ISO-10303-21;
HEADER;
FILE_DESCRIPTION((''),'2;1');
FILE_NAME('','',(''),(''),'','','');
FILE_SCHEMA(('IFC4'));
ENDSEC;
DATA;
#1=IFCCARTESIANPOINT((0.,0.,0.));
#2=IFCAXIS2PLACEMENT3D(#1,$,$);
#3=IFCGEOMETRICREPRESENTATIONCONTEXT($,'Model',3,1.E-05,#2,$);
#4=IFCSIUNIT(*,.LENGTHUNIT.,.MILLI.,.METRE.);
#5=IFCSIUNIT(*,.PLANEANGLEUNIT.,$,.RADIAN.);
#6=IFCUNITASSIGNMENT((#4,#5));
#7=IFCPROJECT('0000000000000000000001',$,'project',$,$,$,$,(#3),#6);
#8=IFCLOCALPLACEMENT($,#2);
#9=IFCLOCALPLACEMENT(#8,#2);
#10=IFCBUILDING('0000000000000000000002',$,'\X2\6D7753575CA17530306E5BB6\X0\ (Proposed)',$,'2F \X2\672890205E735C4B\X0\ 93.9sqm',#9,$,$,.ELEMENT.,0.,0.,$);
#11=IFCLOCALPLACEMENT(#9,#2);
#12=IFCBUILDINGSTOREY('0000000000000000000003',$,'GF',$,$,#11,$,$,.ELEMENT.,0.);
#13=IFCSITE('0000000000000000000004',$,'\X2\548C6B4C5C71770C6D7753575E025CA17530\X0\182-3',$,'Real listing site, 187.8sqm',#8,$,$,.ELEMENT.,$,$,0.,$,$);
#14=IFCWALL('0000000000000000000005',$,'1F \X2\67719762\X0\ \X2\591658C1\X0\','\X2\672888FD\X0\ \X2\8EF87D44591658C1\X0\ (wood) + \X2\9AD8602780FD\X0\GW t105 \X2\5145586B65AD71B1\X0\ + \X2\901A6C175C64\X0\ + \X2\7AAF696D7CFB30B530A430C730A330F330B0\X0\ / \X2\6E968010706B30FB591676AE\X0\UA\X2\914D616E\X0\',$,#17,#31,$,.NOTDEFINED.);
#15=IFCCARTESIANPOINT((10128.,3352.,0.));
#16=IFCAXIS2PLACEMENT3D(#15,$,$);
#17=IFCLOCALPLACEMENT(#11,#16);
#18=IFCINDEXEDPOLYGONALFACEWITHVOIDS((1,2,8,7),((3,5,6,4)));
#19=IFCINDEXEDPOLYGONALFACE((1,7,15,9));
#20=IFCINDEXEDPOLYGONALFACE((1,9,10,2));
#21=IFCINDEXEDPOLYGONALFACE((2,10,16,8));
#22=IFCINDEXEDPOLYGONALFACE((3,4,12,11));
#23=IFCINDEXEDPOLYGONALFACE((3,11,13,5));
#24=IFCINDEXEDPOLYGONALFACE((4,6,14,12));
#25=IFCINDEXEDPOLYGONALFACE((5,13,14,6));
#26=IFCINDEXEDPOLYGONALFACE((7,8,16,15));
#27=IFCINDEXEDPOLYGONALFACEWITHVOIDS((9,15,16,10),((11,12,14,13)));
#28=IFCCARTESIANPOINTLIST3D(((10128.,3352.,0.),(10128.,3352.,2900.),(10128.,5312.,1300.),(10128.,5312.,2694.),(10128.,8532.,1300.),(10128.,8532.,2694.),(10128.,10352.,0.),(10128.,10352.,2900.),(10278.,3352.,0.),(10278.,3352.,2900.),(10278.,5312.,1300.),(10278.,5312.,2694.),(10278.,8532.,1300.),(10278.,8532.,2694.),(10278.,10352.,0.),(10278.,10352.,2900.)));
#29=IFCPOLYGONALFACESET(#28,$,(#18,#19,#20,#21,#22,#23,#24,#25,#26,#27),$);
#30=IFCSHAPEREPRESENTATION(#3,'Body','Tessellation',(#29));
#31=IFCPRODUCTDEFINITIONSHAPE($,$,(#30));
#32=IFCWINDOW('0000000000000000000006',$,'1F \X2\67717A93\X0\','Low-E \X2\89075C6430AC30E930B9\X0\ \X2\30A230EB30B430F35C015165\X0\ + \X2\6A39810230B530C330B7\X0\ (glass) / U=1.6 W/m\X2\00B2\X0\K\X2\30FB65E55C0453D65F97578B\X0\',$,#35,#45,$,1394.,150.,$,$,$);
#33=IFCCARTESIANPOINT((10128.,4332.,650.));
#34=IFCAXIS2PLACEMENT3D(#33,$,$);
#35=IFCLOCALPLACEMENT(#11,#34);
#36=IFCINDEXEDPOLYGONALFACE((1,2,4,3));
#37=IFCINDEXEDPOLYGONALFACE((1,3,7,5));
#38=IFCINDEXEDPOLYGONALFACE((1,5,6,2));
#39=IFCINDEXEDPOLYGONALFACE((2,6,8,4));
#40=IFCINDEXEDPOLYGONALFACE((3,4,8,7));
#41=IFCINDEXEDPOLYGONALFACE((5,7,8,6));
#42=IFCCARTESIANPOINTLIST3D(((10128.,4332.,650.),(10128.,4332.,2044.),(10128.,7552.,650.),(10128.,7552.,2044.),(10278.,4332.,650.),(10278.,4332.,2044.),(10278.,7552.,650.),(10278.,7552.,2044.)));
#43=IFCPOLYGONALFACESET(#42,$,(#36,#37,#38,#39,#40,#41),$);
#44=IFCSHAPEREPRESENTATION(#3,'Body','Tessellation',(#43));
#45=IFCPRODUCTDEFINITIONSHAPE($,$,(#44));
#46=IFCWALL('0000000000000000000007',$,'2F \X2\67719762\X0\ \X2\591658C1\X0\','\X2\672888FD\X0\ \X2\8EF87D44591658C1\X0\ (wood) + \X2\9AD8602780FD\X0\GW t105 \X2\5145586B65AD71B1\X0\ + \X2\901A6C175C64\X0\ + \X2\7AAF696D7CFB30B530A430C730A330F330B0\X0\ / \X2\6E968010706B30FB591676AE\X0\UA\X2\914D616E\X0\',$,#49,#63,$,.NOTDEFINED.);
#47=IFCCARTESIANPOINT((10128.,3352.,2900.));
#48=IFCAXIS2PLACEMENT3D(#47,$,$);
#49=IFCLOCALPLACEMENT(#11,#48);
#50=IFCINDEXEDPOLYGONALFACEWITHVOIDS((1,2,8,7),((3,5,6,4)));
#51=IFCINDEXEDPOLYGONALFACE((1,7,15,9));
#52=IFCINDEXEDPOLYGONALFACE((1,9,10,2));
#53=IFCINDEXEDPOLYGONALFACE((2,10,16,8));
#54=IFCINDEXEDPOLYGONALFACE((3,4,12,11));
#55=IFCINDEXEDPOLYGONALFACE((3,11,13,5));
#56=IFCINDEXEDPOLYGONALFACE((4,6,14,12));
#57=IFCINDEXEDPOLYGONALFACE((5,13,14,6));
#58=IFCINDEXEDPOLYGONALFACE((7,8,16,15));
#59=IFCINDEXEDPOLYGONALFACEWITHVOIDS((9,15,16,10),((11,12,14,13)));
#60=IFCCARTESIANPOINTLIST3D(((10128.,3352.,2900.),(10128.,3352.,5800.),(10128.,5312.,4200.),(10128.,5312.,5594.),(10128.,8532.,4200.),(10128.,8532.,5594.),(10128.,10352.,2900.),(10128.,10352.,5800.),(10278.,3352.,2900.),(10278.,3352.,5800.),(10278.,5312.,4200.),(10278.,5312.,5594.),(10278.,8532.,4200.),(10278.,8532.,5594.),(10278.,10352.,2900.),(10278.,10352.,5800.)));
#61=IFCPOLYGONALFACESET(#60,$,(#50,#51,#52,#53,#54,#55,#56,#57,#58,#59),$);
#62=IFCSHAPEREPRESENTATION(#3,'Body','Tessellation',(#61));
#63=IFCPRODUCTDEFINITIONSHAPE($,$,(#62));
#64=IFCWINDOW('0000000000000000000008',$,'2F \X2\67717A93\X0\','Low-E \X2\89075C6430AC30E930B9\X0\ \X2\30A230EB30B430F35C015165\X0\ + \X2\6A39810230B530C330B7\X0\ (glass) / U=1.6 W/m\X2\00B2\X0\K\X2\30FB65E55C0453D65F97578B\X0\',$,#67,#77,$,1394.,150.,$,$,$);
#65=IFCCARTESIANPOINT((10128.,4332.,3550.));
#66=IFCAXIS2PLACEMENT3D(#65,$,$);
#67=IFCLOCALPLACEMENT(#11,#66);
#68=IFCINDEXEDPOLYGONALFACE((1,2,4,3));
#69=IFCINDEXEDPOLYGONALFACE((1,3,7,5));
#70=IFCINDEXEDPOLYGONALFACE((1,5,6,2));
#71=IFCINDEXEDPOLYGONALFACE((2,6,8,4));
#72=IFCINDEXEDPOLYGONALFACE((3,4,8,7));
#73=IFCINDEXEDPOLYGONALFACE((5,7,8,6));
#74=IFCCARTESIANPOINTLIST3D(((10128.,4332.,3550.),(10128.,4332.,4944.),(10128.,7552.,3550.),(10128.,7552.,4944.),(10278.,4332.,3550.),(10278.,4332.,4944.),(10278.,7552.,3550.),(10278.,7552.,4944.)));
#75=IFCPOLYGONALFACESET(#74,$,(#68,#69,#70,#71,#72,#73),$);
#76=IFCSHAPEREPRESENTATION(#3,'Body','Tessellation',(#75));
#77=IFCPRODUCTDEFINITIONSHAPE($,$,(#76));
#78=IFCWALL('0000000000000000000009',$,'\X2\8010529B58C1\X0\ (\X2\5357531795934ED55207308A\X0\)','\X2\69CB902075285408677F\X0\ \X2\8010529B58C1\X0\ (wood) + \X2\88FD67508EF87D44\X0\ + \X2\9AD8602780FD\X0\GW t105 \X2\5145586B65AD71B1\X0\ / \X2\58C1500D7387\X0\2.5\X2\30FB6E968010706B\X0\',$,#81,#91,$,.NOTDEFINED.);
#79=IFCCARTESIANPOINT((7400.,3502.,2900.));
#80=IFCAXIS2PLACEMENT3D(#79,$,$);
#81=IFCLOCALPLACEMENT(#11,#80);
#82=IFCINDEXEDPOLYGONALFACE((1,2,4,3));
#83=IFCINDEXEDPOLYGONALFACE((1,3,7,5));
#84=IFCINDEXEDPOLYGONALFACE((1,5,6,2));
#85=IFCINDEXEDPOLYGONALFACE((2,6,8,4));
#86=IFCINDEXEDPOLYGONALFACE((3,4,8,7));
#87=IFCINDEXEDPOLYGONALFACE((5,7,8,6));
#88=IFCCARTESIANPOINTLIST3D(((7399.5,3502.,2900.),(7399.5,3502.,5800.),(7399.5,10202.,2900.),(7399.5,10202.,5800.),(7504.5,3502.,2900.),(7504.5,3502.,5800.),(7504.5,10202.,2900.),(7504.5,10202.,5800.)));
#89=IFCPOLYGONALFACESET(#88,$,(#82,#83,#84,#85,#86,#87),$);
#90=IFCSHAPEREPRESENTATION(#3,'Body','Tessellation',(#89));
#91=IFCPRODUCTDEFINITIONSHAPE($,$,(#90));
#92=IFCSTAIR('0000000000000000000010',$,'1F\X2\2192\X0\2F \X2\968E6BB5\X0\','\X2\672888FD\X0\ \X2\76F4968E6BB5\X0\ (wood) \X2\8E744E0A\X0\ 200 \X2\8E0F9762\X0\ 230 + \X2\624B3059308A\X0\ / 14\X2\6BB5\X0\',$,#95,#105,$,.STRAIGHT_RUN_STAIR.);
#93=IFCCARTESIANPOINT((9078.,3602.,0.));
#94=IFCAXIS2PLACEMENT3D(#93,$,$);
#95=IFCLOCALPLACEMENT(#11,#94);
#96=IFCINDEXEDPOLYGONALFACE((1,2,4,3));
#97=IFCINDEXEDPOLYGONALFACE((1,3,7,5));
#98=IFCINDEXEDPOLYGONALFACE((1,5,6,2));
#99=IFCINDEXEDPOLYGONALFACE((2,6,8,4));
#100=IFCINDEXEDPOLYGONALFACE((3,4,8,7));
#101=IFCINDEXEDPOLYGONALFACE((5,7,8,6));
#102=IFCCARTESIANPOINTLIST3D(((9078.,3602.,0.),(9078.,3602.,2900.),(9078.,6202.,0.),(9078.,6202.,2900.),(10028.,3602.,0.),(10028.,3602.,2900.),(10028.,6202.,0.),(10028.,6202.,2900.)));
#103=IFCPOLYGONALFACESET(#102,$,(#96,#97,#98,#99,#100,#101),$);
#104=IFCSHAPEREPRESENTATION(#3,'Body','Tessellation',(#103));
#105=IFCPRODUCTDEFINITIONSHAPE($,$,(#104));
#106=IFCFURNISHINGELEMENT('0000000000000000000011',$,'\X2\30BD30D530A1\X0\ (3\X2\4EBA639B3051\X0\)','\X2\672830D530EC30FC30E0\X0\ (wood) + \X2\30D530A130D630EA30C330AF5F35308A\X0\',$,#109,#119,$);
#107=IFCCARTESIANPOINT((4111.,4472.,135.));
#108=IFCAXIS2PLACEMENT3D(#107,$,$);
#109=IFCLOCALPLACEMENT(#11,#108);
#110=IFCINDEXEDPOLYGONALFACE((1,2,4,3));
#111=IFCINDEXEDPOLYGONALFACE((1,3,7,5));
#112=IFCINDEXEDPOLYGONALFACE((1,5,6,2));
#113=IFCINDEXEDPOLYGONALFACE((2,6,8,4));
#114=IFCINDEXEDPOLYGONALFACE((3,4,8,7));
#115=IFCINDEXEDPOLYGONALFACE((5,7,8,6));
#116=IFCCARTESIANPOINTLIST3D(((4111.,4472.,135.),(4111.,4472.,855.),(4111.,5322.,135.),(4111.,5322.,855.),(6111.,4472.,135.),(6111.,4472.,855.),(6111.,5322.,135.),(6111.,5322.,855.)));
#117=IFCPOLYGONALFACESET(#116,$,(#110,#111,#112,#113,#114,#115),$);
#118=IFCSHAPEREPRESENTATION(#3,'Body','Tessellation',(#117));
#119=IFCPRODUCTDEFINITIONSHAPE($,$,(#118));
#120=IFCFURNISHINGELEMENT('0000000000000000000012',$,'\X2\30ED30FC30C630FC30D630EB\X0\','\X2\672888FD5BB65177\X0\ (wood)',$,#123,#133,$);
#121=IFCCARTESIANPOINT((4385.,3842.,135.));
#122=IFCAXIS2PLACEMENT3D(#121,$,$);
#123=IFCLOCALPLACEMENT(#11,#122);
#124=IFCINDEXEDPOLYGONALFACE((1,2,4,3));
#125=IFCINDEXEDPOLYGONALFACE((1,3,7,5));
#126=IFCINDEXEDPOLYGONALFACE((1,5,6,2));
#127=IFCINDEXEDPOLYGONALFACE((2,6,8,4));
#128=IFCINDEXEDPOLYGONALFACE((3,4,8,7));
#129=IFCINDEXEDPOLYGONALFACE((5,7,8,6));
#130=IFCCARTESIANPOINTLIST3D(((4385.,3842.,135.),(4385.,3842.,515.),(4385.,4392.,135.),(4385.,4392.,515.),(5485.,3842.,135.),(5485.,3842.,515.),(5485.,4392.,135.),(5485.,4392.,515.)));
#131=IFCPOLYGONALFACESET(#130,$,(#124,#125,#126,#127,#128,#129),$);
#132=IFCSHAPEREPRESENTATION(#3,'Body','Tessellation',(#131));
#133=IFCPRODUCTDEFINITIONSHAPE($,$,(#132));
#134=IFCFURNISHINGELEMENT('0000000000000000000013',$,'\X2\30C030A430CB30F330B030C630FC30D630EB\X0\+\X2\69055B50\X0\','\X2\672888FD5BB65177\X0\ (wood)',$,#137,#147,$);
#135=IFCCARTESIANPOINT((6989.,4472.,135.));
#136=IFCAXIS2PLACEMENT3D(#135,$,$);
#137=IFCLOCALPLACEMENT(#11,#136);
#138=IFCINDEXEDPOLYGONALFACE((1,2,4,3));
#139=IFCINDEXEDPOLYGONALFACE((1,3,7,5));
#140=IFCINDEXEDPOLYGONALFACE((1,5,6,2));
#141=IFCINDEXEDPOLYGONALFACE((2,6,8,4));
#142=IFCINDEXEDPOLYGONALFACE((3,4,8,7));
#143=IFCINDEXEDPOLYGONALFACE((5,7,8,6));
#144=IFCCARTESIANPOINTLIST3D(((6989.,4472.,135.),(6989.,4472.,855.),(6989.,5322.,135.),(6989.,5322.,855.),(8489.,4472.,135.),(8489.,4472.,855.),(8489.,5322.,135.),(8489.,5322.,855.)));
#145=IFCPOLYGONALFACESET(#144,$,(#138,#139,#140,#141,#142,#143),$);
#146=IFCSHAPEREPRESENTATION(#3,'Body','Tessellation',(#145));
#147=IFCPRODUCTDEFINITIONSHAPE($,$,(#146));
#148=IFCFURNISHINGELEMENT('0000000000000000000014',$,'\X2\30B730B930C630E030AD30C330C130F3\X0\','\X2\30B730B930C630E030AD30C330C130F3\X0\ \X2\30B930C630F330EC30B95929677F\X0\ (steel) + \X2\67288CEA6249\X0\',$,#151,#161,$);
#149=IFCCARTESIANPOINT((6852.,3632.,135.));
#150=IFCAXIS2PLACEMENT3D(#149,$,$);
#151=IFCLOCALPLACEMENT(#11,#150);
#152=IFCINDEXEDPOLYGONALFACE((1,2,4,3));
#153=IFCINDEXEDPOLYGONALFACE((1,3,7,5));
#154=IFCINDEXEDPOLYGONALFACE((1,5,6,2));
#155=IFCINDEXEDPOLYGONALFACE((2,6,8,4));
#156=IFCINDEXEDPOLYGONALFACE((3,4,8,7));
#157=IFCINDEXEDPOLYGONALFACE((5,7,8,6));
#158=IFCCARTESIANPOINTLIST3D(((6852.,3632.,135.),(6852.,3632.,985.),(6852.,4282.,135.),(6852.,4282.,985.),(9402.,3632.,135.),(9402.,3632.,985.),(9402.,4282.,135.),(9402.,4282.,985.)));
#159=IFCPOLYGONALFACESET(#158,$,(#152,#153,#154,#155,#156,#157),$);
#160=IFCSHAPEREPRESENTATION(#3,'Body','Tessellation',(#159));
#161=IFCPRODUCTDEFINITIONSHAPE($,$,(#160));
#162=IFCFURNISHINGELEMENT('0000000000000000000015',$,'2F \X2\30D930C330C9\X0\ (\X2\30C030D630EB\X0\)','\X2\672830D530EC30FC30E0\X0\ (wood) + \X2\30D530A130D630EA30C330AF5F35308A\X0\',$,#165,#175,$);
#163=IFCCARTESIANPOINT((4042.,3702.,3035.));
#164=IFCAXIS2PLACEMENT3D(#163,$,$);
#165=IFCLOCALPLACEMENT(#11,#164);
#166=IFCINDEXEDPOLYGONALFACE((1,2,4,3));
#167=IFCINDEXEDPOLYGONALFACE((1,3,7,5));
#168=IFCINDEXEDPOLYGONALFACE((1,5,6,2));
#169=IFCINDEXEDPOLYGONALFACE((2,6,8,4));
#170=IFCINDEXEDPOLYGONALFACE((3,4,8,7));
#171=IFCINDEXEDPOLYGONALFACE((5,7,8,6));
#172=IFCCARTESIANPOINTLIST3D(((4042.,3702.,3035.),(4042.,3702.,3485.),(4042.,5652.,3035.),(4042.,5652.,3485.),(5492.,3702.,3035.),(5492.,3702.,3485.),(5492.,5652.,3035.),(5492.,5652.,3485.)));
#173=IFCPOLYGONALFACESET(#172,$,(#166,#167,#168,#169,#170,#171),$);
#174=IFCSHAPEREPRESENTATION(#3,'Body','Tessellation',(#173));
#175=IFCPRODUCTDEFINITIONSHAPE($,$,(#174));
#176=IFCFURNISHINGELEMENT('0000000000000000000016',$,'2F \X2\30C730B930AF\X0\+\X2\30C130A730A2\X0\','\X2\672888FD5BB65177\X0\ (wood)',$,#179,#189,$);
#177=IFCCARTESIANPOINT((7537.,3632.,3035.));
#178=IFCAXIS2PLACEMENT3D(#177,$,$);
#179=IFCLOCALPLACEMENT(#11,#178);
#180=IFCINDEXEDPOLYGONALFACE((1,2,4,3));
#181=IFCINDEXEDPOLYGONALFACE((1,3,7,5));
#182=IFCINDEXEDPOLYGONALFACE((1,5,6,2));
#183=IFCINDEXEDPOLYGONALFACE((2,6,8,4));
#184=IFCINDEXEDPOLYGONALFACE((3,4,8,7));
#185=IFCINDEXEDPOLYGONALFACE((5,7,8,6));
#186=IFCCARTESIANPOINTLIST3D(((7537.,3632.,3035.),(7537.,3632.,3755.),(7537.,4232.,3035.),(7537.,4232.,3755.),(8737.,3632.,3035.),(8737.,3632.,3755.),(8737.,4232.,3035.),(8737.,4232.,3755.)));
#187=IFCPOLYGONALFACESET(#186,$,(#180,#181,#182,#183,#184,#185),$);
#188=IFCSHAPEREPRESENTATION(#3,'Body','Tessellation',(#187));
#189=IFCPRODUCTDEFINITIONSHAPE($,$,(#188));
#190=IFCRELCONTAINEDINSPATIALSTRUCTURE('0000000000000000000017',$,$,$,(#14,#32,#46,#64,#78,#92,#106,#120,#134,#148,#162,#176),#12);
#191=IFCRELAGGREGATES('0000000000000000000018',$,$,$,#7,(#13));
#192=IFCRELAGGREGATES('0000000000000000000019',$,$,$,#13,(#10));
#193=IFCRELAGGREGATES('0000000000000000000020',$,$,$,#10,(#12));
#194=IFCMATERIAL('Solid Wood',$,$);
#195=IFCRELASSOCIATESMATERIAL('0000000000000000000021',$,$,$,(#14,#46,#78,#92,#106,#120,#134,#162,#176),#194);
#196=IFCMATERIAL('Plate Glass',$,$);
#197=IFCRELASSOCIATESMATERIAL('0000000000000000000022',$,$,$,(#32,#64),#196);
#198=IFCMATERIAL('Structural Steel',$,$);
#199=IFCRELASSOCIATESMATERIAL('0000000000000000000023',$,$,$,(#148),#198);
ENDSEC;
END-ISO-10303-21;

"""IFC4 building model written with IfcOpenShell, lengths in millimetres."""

from ifc_helpers import new_model, si_unit, frame, frame_2d, origin, place, context, project, spatial, rectangle, extrude, material, element, fill, save


model = new_model("IFC4")

# Units and contexts
model_context = context("Model", 3, precision=1e-05, world=origin())
ifc_project = project(units=[si_unit("LENGTHUNIT", "METRE", prefix="MILLI"), si_unit("PLANEANGLEUNIT", "RADIAN")], contexts=[model_context])

# Site, building, storey
site_placement = place(None, origin())
site = spatial("IfcSite", under=ifc_project, at=site_placement, Name="和歌山県海南市岡田182-3", ObjectType="Real listing site, 187.8sqm", CompositionType="ELEMENT", RefElevation=0.0)
building_placement = place(site_placement, origin())
building = spatial("IfcBuilding", under=site, at=building_placement, Name="海南岡田の家 (Proposed)", ObjectType="2F 木造平屋 93.9sqm", CompositionType="ELEMENT", ElevationOfRefHeight=0.0, ElevationOfTerrain=0.0)
storey_placement = place(building_placement, origin())
storey = spatial("IfcBuildingStorey", under=building, at=storey_placement, Name="GF", CompositionType="ELEMENT", Elevation=0.0)

# Wall, opening, window
ifc_material_1 = material(Name="Solid Wood")
wall_1_placement = place(storey_placement, frame((10128.0, 3352.0, 0.0)))
wall_1 = element("IfcWall", 1, at=wall_1_placement, inside=storey, material=ifc_material_1, Name="1F 東面 外壁", Description="木製 軸組外壁 (wood) + 高性能GW t105 充填断熱 + 通気層 + 窯業系サイディング / 準耐火・外皮UA配慮", PredefinedType="NOTDEFINED", context=model_context, shape_type="SweptSolid", body=[
    extrude(rectangle(XDim=150.0, YDim=7000.0, at=frame_2d((75.0, 3500.0))), frame((10128.0, 3352.0, 0.0)), (0.0, 0.0, 1.0), 2900.0),
])
opening_1_placement = place(storey_placement, frame((10128.0, 4332.0, 650.0)))
opening_1 = element("IfcOpeningElement", 2, at=opening_1_placement, cuts=wall_1, PredefinedType="NOTDEFINED", context=model_context, shape_type="SweptSolid", body=[
    extrude(rectangle(XDim=150.0, YDim=3220.0, at=frame_2d((75.0, 1610.0))), frame((10128.0, 4332.0, 650.0)), (0.0, 0.0, 1.0), 1394.0),
])
ifc_material_2 = material(Name="Plate Glass")
window_1_placement = place(storey_placement, frame((10128.0, 4332.0, 650.0)))
window_1 = element("IfcWindow", 3, at=window_1_placement, inside=storey, material=ifc_material_2, Name="1F 東窓", Description="Low-E 複層ガラス アルゴン封入 + 樹脂サッシ (glass) / U=1.6 W/m²K・日射取得型", OverallHeight=1394.0, OverallWidth=150.0, context=model_context, shape_type="SweptSolid", body=[
    extrude(rectangle(XDim=150.0, YDim=3220.0, at=frame_2d((75.0, 1610.0))), frame((10128.0, 4332.0, 650.0)), (0.0, 0.0, 1.0), 1394.0),
])
fill(opening_1, window_1)

# Wall, opening, window
wall_2_placement = place(storey_placement, frame((10128.0, 3352.0, 2900.0)))
wall_2 = element("IfcWall", 4, at=wall_2_placement, inside=storey, material=ifc_material_1, Name="2F 東面 外壁", Description="木製 軸組外壁 (wood) + 高性能GW t105 充填断熱 + 通気層 + 窯業系サイディング / 準耐火・外皮UA配慮", PredefinedType="NOTDEFINED", context=model_context, shape_type="SweptSolid", body=[
    extrude(rectangle(XDim=150.0, YDim=7000.0, at=frame_2d((75.0, 3500.0))), frame((10128.0, 3352.0, 2900.0)), (0.0, 0.0, 1.0), 2900.0),
])
opening_2_placement = place(storey_placement, frame((10128.0, 4332.0, 3550.0)))
opening_2 = element("IfcOpeningElement", 5, at=opening_2_placement, cuts=wall_2, PredefinedType="NOTDEFINED", context=model_context, shape_type="SweptSolid", body=[
    extrude(rectangle(XDim=150.0, YDim=3220.0, at=frame_2d((75.0, 1610.0))), frame((10128.0, 4332.0, 3550.0)), (0.0, 0.0, 1.0), 1394.0),
])
window_2_placement = place(storey_placement, frame((10128.0, 4332.0, 3550.0)))
window_2 = element("IfcWindow", 6, at=window_2_placement, inside=storey, material=ifc_material_2, Name="2F 東窓", Description="Low-E 複層ガラス アルゴン封入 + 樹脂サッシ (glass) / U=1.6 W/m²K・日射取得型", OverallHeight=1394.0, OverallWidth=150.0, context=model_context, shape_type="SweptSolid", body=[
    extrude(rectangle(XDim=150.0, YDim=3220.0, at=frame_2d((75.0, 1610.0))), frame((10128.0, 4332.0, 3550.0)), (0.0, 0.0, 1.0), 1394.0),
])
fill(opening_2, window_2)

# Wall
wall_3_placement = place(storey_placement, frame((7400.0, 3502.0, 2900.0)))
element("IfcWall", 7, at=wall_3_placement, inside=storey, material=ifc_material_1, Name="耐力壁 (南北間仕切り)", Description="構造用合板 耐力壁 (wood) + 製材軸組 + 高性能GW t105 充填断熱 / 壁倍率2.5・準耐火", PredefinedType="NOTDEFINED", context=model_context, shape_type="SweptSolid", body=[
    extrude(rectangle(XDim=105.0, YDim=6700.0, at=frame_2d((52.0, 3350.0))), frame((7400.0, 3502.0, 2900.0)), (0.0, 0.0, 1.0), 2900.0),
])

# Stair
stair_placement = place(storey_placement, frame((9078.0, 3602.0, 0.0)))
element("IfcStair", 8, at=stair_placement, inside=storey, material=ifc_material_1, Name="1F→2F 階段", Description="木製 直階段 (wood) 蹴上 200 踏面 230 + 手すり / 14段", PredefinedType="STRAIGHT_RUN_STAIR", context=model_context, shape_type="SweptSolid", body=[
    extrude(rectangle(XDim=950.0, YDim=2600.0, at=frame_2d((475.0, 1300.0))), frame((9078.0, 3602.0, 0.0)), (0.0, 0.0, 1.0), 2900.0),
])

# Furnishing elements
furnishing_1_placement = place(storey_placement, frame((4111.0, 4472.0, 135.0)))
element("IfcFurnishingElement", 9, at=furnishing_1_placement, inside=storey, material=ifc_material_1, Name="ソファ (3人掛け)", Description="木フレーム (wood) + ファブリック張り", context=model_context, shape_type="SweptSolid", body=[
    extrude(rectangle(XDim=2000.0, YDim=850.0, at=frame_2d((1000.0, 425.0))), frame((4111.0, 4472.0, 135.0)), (0.0, 0.0, 1.0), 720.0),
])
furnishing_2_placement = place(storey_placement, frame((4385.0, 3842.0, 135.0)))
element("IfcFurnishingElement", 10, at=furnishing_2_placement, inside=storey, material=ifc_material_1, Name="ローテーブル", Description="木製家具 (wood)", context=model_context, shape_type="SweptSolid", body=[
    extrude(rectangle(XDim=1100.0, YDim=550.0, at=frame_2d((550.0, 275.0))), frame((4385.0, 3842.0, 135.0)), (0.0, 0.0, 1.0), 380.0),
])
furnishing_3_placement = place(storey_placement, frame((6989.0, 4472.0, 135.0)))
element("IfcFurnishingElement", 11, at=furnishing_3_placement, inside=storey, material=ifc_material_1, Name="ダイニングテーブル+椅子", Description="木製家具 (wood)", context=model_context, shape_type="SweptSolid", body=[
    extrude(rectangle(XDim=1500.0, YDim=850.0, at=frame_2d((750.0, 425.0))), frame((6989.0, 4472.0, 135.0)), (0.0, 0.0, 1.0), 720.0),
])
ifc_material_3 = material(Name="Structural Steel")
furnishing_4_placement = place(storey_placement, frame((6852.0, 3632.0, 135.0)))
element("IfcFurnishingElement", 12, at=furnishing_4_placement, inside=storey, material=ifc_material_3, Name="システムキッチン", Description="システムキッチン ステンレス天板 (steel) + 木質扉", context=model_context, shape_type="SweptSolid", body=[
    extrude(rectangle(XDim=2550.0, YDim=650.0, at=frame_2d((1275.0, 325.0))), frame((6852.0, 3632.0, 135.0)), (0.0, 0.0, 1.0), 850.0),
])
furnishing_5_placement = place(storey_placement, frame((4042.0, 3702.0, 3035.0)))
element("IfcFurnishingElement", 13, at=furnishing_5_placement, inside=storey, material=ifc_material_1, Name="2F ベッド (ダブル)", Description="木フレーム (wood) + ファブリック張り", context=model_context, shape_type="SweptSolid", body=[
    extrude(rectangle(XDim=1450.0, YDim=1950.0, at=frame_2d((725.0, 975.0))), frame((4042.0, 3702.0, 3035.0)), (0.0, 0.0, 1.0), 450.0),
])
furnishing_6_placement = place(storey_placement, frame((7537.0, 3632.0, 3035.0)))
element("IfcFurnishingElement", 14, at=furnishing_6_placement, inside=storey, material=ifc_material_1, Name="2F デスク+チェア", Description="木製家具 (wood)", context=model_context, shape_type="SweptSolid", body=[
    extrude(rectangle(XDim=1200.0, YDim=600.0, at=frame_2d((600.0, 300.0))), frame((7537.0, 3632.0, 3035.0)), (0.0, 0.0, 1.0), 720.0),
])

save(model, "model.ifc")
